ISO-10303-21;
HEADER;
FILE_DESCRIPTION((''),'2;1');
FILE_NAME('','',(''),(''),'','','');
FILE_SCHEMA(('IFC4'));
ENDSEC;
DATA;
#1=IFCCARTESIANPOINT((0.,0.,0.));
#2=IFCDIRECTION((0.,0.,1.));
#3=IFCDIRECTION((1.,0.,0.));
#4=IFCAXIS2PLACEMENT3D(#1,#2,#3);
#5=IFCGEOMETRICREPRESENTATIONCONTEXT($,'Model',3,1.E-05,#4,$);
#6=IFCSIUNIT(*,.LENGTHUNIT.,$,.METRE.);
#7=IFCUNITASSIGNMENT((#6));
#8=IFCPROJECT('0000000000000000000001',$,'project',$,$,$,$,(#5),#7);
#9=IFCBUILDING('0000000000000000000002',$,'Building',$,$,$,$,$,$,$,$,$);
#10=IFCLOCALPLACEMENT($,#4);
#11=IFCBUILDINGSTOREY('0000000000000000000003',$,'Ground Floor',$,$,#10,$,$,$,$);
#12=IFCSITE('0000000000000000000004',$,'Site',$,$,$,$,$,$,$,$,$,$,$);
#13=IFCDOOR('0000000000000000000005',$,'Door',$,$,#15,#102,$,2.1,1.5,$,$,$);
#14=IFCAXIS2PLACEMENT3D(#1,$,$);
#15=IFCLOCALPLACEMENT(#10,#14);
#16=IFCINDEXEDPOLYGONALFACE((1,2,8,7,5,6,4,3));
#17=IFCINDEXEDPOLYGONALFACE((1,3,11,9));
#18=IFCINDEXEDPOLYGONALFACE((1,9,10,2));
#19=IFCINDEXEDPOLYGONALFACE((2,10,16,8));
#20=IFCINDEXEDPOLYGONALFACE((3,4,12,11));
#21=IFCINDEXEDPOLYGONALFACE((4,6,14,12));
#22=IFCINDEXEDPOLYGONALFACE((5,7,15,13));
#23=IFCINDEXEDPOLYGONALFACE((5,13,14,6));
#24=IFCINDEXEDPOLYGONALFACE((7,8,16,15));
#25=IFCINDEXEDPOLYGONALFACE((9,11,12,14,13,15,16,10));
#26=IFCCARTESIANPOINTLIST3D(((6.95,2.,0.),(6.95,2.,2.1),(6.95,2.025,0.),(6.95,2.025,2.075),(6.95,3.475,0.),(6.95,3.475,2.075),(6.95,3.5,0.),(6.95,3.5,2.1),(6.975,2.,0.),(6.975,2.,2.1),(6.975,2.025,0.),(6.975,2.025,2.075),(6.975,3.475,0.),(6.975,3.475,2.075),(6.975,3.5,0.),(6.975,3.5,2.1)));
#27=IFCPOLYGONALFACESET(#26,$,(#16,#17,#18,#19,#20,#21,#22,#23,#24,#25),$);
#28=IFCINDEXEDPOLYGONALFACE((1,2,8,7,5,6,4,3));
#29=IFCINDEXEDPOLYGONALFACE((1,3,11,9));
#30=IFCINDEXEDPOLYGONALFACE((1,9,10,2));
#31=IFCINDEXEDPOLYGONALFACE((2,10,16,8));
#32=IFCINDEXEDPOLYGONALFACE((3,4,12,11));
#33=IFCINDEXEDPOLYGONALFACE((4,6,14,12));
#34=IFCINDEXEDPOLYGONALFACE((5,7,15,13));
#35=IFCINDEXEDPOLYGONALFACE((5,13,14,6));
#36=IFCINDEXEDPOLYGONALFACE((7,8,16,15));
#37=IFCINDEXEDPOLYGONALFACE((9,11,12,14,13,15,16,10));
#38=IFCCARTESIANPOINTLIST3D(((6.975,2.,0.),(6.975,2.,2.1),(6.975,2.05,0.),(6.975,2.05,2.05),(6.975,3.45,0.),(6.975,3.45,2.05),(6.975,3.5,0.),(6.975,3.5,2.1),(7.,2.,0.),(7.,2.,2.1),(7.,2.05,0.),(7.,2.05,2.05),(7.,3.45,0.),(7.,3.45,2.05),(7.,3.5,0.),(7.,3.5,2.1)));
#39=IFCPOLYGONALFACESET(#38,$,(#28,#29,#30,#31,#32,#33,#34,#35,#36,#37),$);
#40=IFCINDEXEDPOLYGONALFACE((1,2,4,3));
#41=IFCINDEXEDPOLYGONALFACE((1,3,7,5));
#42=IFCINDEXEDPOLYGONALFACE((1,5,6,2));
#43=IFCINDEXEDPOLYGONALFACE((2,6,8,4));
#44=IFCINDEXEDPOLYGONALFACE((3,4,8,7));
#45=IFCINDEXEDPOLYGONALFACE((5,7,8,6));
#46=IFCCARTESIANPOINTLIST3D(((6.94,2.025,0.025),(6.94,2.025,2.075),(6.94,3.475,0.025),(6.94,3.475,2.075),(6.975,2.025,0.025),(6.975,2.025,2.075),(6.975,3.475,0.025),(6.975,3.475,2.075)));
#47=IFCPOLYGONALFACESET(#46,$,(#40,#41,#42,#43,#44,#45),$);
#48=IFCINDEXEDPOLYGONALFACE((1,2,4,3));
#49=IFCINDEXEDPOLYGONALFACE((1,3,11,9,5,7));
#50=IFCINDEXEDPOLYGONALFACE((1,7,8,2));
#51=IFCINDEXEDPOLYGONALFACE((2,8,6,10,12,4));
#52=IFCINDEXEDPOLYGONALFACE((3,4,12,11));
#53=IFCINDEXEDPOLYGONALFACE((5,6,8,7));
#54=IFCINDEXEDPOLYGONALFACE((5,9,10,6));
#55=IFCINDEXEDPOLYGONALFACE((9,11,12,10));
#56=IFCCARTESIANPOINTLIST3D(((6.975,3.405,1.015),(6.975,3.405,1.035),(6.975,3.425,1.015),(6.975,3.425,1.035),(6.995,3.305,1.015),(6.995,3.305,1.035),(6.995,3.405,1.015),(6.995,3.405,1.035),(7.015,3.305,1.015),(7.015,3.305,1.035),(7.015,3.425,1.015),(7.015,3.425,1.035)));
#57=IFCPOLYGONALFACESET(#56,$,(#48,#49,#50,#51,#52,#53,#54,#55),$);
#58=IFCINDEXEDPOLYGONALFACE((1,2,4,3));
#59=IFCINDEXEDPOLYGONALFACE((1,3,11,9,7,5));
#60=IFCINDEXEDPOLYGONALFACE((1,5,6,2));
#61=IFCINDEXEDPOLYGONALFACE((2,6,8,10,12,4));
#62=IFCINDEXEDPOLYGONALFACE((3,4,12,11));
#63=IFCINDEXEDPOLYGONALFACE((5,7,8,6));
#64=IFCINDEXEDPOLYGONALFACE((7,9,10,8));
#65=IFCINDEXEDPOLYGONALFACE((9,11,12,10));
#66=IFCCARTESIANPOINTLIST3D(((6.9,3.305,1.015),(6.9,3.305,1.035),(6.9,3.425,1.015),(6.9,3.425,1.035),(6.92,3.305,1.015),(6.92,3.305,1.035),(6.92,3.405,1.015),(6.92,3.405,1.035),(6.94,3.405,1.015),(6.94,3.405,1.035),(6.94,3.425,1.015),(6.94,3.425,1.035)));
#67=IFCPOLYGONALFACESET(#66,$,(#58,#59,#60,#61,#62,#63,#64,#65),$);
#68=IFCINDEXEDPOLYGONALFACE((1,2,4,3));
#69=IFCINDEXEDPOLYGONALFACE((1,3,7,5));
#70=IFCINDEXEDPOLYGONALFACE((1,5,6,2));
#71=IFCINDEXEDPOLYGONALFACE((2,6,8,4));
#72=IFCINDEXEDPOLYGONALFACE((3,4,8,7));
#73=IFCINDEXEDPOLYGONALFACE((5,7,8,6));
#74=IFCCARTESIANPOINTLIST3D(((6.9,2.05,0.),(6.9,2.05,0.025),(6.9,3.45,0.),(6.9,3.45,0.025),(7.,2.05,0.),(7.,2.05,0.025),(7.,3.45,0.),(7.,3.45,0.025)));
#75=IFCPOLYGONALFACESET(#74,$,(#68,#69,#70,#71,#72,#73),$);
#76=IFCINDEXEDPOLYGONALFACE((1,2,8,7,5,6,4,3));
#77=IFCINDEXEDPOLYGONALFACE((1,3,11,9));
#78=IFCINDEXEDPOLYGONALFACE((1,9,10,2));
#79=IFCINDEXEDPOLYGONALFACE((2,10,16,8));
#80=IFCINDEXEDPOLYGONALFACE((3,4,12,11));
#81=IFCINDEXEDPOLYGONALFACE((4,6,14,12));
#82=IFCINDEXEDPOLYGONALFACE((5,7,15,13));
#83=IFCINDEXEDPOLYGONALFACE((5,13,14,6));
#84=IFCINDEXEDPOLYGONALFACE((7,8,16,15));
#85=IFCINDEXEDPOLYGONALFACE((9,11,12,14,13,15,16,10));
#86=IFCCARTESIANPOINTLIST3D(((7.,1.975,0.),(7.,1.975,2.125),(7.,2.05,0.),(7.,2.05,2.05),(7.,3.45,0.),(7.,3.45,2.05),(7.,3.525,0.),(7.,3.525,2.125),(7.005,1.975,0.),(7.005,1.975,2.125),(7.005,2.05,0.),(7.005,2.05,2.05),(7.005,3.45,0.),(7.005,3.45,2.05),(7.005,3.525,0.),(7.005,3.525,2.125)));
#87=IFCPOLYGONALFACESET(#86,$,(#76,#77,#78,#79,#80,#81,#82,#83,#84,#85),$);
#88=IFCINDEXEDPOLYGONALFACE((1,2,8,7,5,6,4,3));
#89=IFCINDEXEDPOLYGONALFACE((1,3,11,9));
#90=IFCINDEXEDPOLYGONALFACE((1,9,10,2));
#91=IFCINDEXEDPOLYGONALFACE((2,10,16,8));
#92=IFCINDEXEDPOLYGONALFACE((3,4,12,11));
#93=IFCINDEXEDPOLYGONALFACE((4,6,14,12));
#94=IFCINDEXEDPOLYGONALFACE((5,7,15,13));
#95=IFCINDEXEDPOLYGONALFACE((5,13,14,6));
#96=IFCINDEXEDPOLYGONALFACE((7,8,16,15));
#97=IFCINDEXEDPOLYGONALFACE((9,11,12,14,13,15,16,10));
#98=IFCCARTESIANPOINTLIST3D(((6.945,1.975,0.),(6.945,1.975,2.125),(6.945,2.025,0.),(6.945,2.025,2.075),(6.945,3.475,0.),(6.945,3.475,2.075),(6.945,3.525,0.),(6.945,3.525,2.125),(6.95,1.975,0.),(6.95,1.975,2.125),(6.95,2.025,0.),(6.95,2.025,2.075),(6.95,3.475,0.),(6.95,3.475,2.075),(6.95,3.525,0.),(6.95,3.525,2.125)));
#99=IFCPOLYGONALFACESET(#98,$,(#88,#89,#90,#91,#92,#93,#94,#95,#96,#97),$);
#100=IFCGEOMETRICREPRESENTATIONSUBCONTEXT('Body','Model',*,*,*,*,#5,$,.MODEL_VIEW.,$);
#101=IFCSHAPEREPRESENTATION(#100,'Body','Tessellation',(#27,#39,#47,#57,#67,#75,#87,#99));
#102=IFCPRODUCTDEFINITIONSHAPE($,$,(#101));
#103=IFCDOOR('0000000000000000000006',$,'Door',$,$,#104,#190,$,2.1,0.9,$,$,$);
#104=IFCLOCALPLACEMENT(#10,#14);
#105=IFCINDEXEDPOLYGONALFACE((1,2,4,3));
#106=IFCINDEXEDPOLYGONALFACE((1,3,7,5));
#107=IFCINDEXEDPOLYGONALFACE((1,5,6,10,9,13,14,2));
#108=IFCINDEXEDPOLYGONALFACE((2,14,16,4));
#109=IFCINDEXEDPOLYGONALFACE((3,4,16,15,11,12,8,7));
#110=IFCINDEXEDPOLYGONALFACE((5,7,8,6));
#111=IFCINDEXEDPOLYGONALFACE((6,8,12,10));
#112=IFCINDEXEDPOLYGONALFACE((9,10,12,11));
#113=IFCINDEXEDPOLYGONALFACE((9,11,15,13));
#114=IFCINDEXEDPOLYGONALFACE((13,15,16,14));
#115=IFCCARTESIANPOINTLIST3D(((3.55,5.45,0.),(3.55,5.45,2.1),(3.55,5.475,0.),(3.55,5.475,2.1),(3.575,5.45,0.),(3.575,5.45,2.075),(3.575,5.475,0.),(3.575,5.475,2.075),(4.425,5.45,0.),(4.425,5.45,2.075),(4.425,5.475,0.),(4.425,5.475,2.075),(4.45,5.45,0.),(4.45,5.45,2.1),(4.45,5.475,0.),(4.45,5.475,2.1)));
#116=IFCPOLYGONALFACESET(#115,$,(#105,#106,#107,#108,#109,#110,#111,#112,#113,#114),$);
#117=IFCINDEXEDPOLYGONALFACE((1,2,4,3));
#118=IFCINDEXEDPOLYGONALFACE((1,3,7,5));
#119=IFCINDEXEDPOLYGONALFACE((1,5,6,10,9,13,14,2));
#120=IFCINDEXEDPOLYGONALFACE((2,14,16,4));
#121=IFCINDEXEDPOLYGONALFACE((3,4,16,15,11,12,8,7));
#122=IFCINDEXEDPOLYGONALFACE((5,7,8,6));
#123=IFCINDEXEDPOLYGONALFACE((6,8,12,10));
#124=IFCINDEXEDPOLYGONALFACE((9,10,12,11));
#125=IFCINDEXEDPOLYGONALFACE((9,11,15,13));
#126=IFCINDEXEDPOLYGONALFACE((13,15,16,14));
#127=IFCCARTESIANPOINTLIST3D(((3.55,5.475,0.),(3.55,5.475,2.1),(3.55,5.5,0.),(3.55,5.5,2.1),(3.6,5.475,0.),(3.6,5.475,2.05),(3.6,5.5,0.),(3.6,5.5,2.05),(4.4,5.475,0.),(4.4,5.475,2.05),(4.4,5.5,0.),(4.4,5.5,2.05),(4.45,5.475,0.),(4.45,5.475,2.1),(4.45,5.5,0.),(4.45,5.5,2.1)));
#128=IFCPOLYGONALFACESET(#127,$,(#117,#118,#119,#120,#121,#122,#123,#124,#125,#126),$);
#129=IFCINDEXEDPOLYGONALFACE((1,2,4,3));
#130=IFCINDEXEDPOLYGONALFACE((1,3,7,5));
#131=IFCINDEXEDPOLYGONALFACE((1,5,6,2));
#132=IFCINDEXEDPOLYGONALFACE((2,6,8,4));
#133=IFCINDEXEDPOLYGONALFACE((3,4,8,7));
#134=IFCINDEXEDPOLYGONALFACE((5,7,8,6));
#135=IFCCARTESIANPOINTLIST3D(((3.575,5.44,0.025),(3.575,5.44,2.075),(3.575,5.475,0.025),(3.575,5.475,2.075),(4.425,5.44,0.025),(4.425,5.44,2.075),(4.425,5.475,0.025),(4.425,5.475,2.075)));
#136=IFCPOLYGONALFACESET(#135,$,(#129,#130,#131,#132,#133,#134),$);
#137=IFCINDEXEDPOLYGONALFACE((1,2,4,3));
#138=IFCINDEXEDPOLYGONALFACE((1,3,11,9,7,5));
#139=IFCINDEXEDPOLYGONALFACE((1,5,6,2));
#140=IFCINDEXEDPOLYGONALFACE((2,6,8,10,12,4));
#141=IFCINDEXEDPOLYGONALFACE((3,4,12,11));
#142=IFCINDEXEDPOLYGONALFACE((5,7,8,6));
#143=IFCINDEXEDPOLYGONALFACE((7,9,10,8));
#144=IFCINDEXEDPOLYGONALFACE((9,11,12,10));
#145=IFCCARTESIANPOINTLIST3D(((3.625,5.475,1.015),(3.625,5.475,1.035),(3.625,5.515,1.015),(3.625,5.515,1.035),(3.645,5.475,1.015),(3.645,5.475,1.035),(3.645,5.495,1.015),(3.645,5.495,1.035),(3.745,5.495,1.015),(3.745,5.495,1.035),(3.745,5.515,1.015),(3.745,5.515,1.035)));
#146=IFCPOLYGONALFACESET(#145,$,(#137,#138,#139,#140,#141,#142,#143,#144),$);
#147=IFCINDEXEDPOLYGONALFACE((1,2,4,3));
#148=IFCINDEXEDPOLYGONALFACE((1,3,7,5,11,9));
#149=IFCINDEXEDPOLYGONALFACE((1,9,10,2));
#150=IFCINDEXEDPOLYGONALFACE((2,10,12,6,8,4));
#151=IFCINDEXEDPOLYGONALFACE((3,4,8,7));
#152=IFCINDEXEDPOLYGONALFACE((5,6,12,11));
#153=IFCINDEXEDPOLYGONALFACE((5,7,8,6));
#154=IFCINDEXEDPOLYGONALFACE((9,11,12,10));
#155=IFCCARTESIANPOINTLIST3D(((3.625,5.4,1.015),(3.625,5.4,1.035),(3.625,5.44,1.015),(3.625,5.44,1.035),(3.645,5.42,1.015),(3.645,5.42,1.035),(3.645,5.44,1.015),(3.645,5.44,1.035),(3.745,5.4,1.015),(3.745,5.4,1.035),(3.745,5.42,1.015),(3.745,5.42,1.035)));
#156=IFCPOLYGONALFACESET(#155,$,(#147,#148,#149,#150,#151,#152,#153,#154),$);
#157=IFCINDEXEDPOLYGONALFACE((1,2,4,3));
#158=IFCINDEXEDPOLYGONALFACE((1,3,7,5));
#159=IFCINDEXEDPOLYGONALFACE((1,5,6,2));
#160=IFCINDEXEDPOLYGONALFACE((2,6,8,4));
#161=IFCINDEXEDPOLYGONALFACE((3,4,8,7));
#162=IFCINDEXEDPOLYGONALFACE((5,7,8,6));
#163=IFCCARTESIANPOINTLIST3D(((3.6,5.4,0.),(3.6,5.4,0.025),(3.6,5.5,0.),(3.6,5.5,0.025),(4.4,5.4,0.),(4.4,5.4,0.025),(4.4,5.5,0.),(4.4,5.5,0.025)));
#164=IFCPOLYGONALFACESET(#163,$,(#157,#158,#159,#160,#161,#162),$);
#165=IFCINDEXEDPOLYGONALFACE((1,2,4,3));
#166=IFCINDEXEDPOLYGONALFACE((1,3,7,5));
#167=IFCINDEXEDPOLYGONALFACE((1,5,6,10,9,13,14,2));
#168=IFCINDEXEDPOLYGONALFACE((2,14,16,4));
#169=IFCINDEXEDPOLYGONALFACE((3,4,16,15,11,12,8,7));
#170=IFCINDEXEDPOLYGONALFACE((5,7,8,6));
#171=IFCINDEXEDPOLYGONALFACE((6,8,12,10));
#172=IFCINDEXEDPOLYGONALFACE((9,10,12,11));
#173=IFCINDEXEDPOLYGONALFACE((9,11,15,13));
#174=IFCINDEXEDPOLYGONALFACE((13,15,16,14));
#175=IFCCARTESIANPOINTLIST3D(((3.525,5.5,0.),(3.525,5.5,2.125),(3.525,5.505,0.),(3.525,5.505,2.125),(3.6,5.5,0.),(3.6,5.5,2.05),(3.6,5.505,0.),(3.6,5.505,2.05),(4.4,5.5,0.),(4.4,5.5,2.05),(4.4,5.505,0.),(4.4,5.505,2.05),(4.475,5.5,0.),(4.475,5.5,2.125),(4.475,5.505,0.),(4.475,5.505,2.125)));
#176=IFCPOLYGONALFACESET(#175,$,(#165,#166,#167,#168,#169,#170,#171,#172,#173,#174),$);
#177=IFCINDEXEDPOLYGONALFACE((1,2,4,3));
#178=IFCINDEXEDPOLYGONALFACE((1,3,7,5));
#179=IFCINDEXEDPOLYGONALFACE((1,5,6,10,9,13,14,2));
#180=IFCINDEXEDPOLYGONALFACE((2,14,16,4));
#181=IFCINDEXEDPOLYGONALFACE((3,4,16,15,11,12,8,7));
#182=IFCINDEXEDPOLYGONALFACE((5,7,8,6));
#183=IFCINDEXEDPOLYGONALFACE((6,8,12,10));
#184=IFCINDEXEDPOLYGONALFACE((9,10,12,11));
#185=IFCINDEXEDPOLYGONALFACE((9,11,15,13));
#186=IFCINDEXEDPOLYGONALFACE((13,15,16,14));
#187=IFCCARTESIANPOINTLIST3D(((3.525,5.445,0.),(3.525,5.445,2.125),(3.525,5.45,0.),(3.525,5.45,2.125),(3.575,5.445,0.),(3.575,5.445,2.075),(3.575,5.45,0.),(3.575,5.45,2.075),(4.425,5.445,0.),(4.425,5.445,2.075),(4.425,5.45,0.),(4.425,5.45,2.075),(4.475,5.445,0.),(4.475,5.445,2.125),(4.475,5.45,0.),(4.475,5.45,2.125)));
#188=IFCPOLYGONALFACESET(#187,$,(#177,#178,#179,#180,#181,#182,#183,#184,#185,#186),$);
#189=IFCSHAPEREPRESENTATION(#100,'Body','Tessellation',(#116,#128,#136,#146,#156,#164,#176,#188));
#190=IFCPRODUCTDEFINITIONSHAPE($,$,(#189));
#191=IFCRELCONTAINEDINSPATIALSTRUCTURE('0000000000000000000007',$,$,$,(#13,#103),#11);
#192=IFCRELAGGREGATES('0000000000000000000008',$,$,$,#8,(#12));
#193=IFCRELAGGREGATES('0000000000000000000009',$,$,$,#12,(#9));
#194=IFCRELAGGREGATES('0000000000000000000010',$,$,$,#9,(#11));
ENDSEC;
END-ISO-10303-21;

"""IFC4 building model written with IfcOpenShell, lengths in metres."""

from ifc_helpers import new_model, si_unit, frame, origin_with_axes, place, context, subcontext, project, spatial, line, indexed_curve, outline, extrude, element, save


model = new_model("IFC4")

# Units and contexts
model_context = context("Model", 3, precision=1e-05, world=origin_with_axes())
body_context = subcontext(model_context, "Body", "Model", "MODEL_VIEW")
ifc_project = project(units=[si_unit("LENGTHUNIT", "METRE")], contexts=[model_context])

# Site, building, storey
site = spatial("IfcSite", under=ifc_project, Name="Site")
building = spatial("IfcBuilding", under=site, Name="Building")
storey_placement = place(None, origin_with_axes())
storey = spatial("IfcBuildingStorey", under=building, at=storey_placement, Name="Ground Floor")

# Doors
door_1_placement = place(storey_placement, frame((7.0, 2.0, 0.0), z_axis=(0.0, 0.0, 1.0), x_axis=(0.0, 1.0, 0.0)))
element("IfcDoor", 1, at=door_1_placement, inside=storey, Name="Door", OverallHeight=2.1, OverallWidth=1.5, context=body_context, shape_type="SweptSolid", body=[
    extrude(outline(indexed_curve([(0.0, 0.0), (0.0, 2.1), (1.5, 2.1), (1.5, 0.0), (1.475, 0.0), (1.475, 2.075), (0.025, 2.075), (0.025, 0.0)], segments=[line(1, 2, 3, 4, 5, 6, 7, 8, 1)])), frame((0.0, 0.025, 0.0), z_axis=(0.0, -1.0, 0.0), x_axis=(1.0, 0.0, 0.0)), (0.0, 0.0, -1.0), 0.025),
    extrude(outline(indexed_curve([(0.0, 0.0), (0.0, 2.1), (1.5, 2.1), (1.5, 0.0), (1.45, 0.0), (1.45, 2.05), (0.05, 2.05), (0.05, 0.0)], segments=[line(1, 2, 3, 4, 5, 6, 7, 8, 1)])), frame((0.0, 0.0, 0.0), z_axis=(0.0, -1.0, 0.0), x_axis=(1.0, 0.0, 0.0)), (0.0, 0.0, -1.0), 0.025),
    extrude(outline(indexed_curve([(0.0, 0.0), (1.45, 0.0), (1.45, 0.035), (0.0, 0.035)], segments=[line(1, 2, 3, 4, 1)])), frame((0.025, 0.025, 0.025), z_axis=(0.0, 0.0, 1.0), x_axis=(1.0, 0.0, 0.0)), (0.0, 0.0, 1.0), 2.05),
    extrude(outline(indexed_curve([(0.0, 0.0), (0.0, -0.04), (-0.12, -0.04), (-0.12, -0.02), (-0.02, -0.02), (-0.02, 0.0)], segments=[line(1, 2, 3, 4, 5, 6, 1)])), frame((1.425, 0.025, 1.015), z_axis=(0.0, 0.0, 1.0), x_axis=(1.0, 0.0, 0.0)), (0.0, 0.0, 1.0), 0.02),
    extrude(outline(indexed_curve([(0.0, 0.0), (0.0, 0.04), (-0.12, 0.04), (-0.12, 0.02), (-0.02, 0.02), (-0.02, 0.0)], segments=[line(1, 2, 3, 4, 5, 6, 1)])), frame((1.425, 0.06, 1.015), z_axis=(0.0, 0.0, 1.0), x_axis=(1.0, 0.0, 0.0)), (0.0, 0.0, 1.0), 0.02),
    extrude(outline(indexed_curve([(0.0, 0.0), (1.4, 0.0), (1.4, 0.1), (0.0, 0.1)], segments=[line(1, 2, 3, 4, 1)])), frame((0.05, 0.0, 0.0), z_axis=(0.0, 0.0, 1.0), x_axis=(1.0, 0.0, 0.0)), (0.0, 0.0, 1.0), 0.025),
    extrude(outline(indexed_curve([(0.0, 0.0), (0.0, 2.125), (1.55, 2.125), (1.55, 0.0), (1.475, 0.0), (1.475, 2.05), (0.075, 2.05), (0.075, 0.0)], segments=[line(1, 2, 3, 4, 5, 6, 7, 8, 1)])), frame((-0.025, -0.005, 0.0), z_axis=(0.0, -1.0, 0.0), x_axis=(1.0, 0.0, 0.0)), (0.0, 0.0, -1.0), 0.005),
    extrude(outline(indexed_curve([(0.0, 0.0), (0.0, 2.125), (1.55, 2.125), (1.55, 0.0), (1.5, 0.0), (1.5, 2.075), (0.05, 2.075), (0.05, 0.0)], segments=[line(1, 2, 3, 4, 5, 6, 7, 8, 1)])), frame((-0.025, 0.05, 0.0), z_axis=(0.0, -1.0, 0.0), x_axis=(1.0, 0.0, 0.0)), (0.0, 0.0, -1.0), 0.005),
])
door_2_placement = place(storey_placement, frame((4.45, 5.5, 0.0), z_axis=(0.0, 0.0, 1.0), x_axis=(-1.0, 0.0, 0.0)))
element("IfcDoor", 2, at=door_2_placement, inside=storey, Name="Door", OverallHeight=2.1, OverallWidth=0.9, context=body_context, shape_type="SweptSolid", body=[
    extrude(outline(indexed_curve([(0.0, 0.0), (0.0, 2.1), (0.9, 2.1), (0.9, 0.0), (0.875, 0.0), (0.875, 2.075), (0.025, 2.075), (0.025, 0.0)], segments=[line(1, 2, 3, 4, 5, 6, 7, 8, 1)])), frame((0.0, 0.025, 0.0), z_axis=(0.0, -1.0, 0.0), x_axis=(1.0, 0.0, 0.0)), (0.0, 0.0, -1.0), 0.025),
    extrude(outline(indexed_curve([(0.0, 0.0), (0.0, 2.1), (0.9, 2.1), (0.9, 0.0), (0.85, 0.0), (0.85, 2.05), (0.05, 2.05), (0.05, 0.0)], segments=[line(1, 2, 3, 4, 5, 6, 7, 8, 1)])), frame((0.0, 0.0, 0.0), z_axis=(0.0, -1.0, 0.0), x_axis=(1.0, 0.0, 0.0)), (0.0, 0.0, -1.0), 0.025),
    extrude(outline(indexed_curve([(0.0, 0.0), (0.85, 0.0), (0.85, 0.035), (0.0, 0.035)], segments=[line(1, 2, 3, 4, 1)])), frame((0.025, 0.025, 0.025), z_axis=(0.0, 0.0, 1.0), x_axis=(1.0, 0.0, 0.0)), (0.0, 0.0, 1.0), 2.05),
    extrude(outline(indexed_curve([(0.0, 0.0), (0.0, -0.04), (-0.12, -0.04), (-0.12, -0.02), (-0.02, -0.02), (-0.02, 0.0)], segments=[line(1, 2, 3, 4, 5, 6, 1)])), frame((0.825, 0.025, 1.015), z_axis=(0.0, 0.0, 1.0), x_axis=(1.0, 0.0, 0.0)), (0.0, 0.0, 1.0), 0.02),
    extrude(outline(indexed_curve([(0.0, 0.0), (0.0, 0.04), (-0.12, 0.04), (-0.12, 0.02), (-0.02, 0.02), (-0.02, 0.0)], segments=[line(1, 2, 3, 4, 5, 6, 1)])), frame((0.825, 0.06, 1.015), z_axis=(0.0, 0.0, 1.0), x_axis=(1.0, 0.0, 0.0)), (0.0, 0.0, 1.0), 0.02),
    extrude(outline(indexed_curve([(0.0, 0.0), (0.8, 0.0), (0.8, 0.1), (0.0, 0.1)], segments=[line(1, 2, 3, 4, 1)])), frame((0.05, 0.0, 0.0), z_axis=(0.0, 0.0, 1.0), x_axis=(1.0, 0.0, 0.0)), (0.0, 0.0, 1.0), 0.025),
    extrude(outline(indexed_curve([(0.0, 0.0), (0.0, 2.125), (0.95, 2.125), (0.95, 0.0), (0.875, 0.0), (0.875, 2.05), (0.075, 2.05), (0.075, 0.0)], segments=[line(1, 2, 3, 4, 5, 6, 7, 8, 1)])), frame((-0.025, -0.005, 0.0), z_axis=(0.0, -1.0, 0.0), x_axis=(1.0, 0.0, 0.0)), (0.0, 0.0, -1.0), 0.005),
    extrude(outline(indexed_curve([(0.0, 0.0), (0.0, 2.125), (0.95, 2.125), (0.95, 0.0), (0.9, 0.0), (0.9, 2.075), (0.05, 2.075), (0.05, 0.0)], segments=[line(1, 2, 3, 4, 5, 6, 7, 8, 1)])), frame((-0.025, 0.05, 0.0), z_axis=(0.0, -1.0, 0.0), x_axis=(1.0, 0.0, 0.0)), (0.0, 0.0, -1.0), 0.005),
])

save(model, "model.ifc")
